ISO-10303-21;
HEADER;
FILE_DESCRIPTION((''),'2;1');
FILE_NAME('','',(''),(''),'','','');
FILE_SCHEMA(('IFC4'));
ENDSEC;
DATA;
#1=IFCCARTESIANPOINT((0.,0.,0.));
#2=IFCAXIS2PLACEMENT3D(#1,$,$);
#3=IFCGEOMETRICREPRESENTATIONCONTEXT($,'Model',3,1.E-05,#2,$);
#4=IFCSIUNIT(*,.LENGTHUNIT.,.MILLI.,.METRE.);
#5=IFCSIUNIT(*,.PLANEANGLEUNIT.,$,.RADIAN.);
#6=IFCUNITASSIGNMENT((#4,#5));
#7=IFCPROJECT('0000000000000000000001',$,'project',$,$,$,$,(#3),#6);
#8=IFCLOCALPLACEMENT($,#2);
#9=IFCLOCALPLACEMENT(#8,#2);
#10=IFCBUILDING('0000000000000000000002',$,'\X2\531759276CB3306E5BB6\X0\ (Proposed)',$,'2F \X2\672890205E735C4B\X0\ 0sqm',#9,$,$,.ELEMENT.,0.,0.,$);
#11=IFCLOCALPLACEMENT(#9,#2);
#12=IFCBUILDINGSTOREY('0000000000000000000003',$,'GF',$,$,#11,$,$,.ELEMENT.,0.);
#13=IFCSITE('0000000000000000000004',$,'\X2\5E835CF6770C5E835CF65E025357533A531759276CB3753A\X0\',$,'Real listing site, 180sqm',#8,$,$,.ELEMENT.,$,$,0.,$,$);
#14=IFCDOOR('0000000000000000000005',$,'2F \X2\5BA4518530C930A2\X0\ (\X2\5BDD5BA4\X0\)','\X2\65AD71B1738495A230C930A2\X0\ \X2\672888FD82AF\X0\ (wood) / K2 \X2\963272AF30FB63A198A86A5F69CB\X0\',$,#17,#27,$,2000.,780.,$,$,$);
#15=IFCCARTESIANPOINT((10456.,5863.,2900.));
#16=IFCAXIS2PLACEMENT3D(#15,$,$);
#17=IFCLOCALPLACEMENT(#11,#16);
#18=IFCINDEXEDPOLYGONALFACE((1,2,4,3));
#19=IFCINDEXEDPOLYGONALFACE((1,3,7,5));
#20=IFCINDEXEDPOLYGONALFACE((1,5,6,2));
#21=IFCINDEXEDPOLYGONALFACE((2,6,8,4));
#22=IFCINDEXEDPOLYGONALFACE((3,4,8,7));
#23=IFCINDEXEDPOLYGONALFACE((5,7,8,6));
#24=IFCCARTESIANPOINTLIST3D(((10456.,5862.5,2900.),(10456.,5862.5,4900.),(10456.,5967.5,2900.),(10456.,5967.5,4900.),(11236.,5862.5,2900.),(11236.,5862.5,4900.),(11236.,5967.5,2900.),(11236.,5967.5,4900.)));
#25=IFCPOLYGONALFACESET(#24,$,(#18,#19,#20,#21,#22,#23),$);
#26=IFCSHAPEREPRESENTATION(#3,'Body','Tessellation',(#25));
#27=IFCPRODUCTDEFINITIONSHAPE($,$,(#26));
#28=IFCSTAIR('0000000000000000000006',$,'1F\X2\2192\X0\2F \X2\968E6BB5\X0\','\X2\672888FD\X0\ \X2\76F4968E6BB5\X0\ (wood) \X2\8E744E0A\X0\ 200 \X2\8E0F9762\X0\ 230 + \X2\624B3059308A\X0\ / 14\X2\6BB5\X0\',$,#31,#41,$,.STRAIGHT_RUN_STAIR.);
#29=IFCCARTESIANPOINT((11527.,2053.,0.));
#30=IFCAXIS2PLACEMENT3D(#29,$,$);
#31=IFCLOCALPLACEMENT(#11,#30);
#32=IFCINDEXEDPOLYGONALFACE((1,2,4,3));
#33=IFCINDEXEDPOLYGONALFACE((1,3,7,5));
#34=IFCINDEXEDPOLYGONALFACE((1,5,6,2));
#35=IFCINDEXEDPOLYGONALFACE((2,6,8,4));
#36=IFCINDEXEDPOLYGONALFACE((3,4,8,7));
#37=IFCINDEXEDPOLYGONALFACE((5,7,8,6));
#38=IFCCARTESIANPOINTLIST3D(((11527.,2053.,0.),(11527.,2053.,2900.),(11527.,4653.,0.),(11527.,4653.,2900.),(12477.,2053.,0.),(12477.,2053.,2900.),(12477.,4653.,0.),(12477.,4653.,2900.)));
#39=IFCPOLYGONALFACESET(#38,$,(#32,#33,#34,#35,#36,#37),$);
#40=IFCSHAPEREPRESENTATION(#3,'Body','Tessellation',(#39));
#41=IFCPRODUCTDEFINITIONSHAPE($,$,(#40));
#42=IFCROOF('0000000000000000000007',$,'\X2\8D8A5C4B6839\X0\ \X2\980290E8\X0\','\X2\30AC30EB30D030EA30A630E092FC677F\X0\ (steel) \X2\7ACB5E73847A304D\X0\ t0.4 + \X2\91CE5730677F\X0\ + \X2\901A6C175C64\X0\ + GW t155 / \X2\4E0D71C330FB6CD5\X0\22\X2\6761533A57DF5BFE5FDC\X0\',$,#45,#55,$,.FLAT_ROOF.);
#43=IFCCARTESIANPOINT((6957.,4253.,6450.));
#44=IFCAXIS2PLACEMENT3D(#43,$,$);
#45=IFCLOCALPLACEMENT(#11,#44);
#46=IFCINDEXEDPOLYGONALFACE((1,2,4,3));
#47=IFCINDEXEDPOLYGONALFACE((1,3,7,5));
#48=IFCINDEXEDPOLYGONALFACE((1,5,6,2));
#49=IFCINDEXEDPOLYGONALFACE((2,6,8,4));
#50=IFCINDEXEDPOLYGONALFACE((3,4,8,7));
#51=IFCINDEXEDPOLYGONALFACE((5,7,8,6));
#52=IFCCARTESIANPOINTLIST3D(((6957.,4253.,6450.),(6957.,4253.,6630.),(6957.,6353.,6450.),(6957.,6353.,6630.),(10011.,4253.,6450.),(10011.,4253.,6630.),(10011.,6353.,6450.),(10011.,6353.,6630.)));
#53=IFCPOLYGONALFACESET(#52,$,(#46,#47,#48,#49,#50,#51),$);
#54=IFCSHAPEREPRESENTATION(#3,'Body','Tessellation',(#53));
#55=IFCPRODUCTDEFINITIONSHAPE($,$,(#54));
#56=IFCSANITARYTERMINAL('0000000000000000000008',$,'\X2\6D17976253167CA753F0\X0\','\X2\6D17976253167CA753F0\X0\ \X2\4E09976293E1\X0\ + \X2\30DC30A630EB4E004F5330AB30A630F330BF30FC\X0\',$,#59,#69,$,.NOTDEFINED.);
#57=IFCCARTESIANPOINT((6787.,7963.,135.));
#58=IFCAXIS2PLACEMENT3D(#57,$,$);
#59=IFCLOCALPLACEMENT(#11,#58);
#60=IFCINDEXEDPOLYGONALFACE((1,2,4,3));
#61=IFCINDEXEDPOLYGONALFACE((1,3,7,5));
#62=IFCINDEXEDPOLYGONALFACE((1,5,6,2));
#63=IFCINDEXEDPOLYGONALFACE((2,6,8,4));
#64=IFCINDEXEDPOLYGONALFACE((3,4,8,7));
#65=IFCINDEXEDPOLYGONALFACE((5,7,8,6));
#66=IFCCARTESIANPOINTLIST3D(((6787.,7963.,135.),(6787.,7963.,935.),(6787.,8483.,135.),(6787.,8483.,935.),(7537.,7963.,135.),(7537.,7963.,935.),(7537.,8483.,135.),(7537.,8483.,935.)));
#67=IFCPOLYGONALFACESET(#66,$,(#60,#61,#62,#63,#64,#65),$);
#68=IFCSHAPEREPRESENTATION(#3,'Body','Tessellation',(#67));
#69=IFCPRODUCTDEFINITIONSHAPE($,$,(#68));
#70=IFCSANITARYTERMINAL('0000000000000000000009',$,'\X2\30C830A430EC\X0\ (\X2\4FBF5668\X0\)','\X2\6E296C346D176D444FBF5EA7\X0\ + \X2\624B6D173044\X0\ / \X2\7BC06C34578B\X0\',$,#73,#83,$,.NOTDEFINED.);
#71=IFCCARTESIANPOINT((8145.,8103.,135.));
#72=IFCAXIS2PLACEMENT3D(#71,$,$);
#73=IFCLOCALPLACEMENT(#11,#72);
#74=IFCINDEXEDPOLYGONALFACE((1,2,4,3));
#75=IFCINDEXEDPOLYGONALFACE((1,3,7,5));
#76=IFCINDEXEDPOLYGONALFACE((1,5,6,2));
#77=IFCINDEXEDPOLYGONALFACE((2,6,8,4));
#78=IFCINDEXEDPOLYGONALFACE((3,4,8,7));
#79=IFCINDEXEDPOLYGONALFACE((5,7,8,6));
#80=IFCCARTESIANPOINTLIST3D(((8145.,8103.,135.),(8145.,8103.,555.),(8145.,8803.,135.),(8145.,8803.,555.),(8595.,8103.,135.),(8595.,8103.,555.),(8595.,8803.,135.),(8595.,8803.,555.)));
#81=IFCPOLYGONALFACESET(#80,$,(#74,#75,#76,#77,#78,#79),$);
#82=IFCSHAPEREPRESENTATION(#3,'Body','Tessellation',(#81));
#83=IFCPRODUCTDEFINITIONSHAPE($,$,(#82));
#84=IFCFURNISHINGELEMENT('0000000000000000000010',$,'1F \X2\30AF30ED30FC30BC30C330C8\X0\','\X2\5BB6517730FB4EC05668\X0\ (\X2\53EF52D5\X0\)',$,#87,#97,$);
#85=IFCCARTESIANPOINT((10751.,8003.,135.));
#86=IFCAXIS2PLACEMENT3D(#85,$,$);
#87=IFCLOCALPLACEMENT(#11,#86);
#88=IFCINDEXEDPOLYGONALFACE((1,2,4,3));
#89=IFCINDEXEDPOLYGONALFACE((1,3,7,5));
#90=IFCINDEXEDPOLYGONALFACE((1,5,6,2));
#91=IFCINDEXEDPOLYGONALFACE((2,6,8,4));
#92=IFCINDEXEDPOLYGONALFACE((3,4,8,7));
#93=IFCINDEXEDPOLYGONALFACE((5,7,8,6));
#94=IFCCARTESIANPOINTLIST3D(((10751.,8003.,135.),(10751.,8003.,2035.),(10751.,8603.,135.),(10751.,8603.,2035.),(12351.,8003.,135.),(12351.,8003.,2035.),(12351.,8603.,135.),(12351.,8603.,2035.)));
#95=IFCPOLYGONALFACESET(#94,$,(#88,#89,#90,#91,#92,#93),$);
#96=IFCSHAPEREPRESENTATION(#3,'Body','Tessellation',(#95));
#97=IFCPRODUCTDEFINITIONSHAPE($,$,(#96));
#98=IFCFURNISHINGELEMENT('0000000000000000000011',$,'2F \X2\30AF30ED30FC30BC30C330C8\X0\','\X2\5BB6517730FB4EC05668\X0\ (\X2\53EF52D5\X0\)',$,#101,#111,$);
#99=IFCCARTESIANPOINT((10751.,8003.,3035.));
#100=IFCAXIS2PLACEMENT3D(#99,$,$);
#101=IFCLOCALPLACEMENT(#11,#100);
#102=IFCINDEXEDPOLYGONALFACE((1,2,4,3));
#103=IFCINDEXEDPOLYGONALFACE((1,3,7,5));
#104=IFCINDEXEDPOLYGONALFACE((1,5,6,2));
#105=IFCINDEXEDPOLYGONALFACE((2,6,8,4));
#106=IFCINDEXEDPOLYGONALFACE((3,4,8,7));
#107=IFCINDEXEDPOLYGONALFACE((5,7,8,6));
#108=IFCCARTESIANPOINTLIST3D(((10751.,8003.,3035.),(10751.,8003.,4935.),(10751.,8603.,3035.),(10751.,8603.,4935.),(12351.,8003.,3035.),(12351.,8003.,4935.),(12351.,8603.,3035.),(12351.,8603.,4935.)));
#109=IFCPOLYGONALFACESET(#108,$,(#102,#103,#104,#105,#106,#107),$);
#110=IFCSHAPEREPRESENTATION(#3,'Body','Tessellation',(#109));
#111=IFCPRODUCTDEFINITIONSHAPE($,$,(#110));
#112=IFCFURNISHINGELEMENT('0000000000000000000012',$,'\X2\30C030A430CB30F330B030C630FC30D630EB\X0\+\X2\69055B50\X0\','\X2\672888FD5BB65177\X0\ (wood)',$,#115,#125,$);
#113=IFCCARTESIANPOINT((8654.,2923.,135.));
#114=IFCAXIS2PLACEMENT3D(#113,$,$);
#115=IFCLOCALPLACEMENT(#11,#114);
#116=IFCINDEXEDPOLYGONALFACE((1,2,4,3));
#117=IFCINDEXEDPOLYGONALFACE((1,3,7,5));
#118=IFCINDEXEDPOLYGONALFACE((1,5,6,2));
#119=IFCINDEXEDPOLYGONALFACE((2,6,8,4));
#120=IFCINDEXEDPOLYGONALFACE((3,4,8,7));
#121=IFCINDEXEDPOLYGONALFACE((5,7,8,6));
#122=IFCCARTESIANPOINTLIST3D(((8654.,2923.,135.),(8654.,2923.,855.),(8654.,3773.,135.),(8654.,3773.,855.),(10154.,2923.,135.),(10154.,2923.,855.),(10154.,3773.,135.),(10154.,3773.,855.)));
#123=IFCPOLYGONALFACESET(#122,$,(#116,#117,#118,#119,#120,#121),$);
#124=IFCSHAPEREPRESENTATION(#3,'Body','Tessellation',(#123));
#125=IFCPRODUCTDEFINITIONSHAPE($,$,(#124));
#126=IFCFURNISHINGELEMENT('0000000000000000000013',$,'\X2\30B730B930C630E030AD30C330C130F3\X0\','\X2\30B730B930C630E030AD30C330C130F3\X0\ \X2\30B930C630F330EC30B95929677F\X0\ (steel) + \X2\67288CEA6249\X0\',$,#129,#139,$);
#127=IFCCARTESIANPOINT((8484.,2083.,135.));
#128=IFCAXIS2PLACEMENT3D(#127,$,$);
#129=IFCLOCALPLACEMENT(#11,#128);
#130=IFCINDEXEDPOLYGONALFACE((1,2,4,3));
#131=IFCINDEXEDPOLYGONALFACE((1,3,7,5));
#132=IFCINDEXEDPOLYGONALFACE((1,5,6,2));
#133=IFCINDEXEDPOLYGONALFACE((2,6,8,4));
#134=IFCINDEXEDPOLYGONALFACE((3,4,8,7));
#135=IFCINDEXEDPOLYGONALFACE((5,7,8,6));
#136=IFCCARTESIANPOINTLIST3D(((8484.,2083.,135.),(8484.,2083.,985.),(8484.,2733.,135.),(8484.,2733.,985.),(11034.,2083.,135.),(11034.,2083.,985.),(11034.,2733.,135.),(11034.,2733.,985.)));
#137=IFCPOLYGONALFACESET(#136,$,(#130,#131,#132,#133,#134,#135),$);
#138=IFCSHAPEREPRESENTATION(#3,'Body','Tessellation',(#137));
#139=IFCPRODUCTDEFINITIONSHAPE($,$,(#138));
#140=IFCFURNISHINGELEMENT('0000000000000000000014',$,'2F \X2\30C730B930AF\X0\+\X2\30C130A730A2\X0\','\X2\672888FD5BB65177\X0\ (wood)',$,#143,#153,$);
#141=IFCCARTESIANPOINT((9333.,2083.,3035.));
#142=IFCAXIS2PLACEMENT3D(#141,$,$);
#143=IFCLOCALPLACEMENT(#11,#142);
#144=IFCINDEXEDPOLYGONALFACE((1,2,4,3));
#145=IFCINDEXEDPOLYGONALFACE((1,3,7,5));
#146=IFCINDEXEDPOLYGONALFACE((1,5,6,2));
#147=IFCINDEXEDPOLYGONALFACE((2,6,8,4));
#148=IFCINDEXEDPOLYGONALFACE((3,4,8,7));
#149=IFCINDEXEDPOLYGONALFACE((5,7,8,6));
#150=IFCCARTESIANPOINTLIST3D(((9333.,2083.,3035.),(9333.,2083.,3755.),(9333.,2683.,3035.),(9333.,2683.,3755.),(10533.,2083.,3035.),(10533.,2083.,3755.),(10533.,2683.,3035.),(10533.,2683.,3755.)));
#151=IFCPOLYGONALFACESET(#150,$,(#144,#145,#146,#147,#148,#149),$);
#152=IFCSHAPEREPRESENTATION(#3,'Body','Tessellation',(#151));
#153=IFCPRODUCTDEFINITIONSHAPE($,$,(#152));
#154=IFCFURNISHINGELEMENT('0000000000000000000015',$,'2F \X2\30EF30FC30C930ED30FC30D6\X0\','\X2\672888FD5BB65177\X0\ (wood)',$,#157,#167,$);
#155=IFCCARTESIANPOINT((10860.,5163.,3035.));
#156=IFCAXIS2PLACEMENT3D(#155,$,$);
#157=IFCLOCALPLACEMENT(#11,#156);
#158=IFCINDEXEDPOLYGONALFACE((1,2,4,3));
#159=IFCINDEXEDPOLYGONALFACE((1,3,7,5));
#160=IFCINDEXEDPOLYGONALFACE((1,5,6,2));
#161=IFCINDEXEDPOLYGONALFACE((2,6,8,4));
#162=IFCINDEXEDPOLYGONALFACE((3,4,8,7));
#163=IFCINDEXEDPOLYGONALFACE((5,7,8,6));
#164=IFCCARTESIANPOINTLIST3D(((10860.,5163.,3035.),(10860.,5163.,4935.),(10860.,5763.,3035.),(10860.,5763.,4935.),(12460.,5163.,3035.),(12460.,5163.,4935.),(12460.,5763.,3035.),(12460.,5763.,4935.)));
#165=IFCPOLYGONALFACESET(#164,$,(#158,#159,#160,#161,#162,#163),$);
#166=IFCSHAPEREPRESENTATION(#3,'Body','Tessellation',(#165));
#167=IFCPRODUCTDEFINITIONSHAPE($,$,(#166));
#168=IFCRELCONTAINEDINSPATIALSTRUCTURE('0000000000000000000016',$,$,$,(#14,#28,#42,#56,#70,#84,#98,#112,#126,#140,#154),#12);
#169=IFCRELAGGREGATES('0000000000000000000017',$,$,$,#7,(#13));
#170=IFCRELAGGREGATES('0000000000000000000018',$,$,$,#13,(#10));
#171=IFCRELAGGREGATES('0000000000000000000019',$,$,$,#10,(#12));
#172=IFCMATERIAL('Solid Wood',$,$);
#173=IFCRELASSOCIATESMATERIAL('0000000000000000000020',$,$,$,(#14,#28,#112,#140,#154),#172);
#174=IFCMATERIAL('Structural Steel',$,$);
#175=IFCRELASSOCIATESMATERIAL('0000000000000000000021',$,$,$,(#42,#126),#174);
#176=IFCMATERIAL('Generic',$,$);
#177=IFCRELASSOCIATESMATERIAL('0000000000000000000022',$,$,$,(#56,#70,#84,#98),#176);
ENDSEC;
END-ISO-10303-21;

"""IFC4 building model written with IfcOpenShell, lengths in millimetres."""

from ifc_helpers import new_model, si_unit, frame, frame_2d, origin, place, context, project, spatial, rectangle, extrude, material, element, save


model = new_model("IFC4")

# Units and contexts
model_context = context("Model", 3, precision=1e-05, world=origin())
ifc_project = project(units=[si_unit("LENGTHUNIT", "METRE", prefix="MILLI"), si_unit("PLANEANGLEUNIT", "RADIAN")], contexts=[model_context])

# Site, building, storey
site_placement = place(None, origin())
site = spatial("IfcSite", under=ifc_project, at=site_placement, Name="広島県広島市南区北大河町", ObjectType="Real listing site, 180sqm", CompositionType="ELEMENT", RefElevation=0.0)
building_placement = place(site_placement, origin())
building = spatial("IfcBuilding", under=site, at=building_placement, Name="北大河の家 (Proposed)", ObjectType="2F 木造平屋 0sqm", CompositionType="ELEMENT", ElevationOfRefHeight=0.0, ElevationOfTerrain=0.0)
storey_placement = place(building_placement, origin())
storey = spatial("IfcBuildingStorey", under=building, at=storey_placement, Name="GF", CompositionType="ELEMENT", Elevation=0.0)

# Shared definitions
ifc_material_1 = material(Name="Solid Wood")

# Door
door_1_placement = place(storey_placement, frame((10456.0, 5863.0, 2900.0)))
element("IfcDoor", 1, at=door_1_placement, inside=storey, material=ifc_material_1, Name="2F 室内ドア (寝室)", Description="断熱玄関ドア 木製芯 (wood) / K2 防犯・採風機構", OverallHeight=2000.0, OverallWidth=780.0, context=model_context, shape_type="SweptSolid", body=[
    extrude(rectangle(XDim=780.0, YDim=105.0, at=frame_2d((390.0, 52.0))), frame((10456.0, 5863.0, 2900.0)), (0.0, 0.0, 1.0), 2000.0),
])

# Stair
stair_placement = place(storey_placement, frame((11527.0, 2053.0, 0.0)))
element("IfcStair", 2, at=stair_placement, inside=storey, material=ifc_material_1, Name="1F→2F 階段", Description="木製 直階段 (wood) 蹴上 200 踏面 230 + 手すり / 14段", PredefinedType="STRAIGHT_RUN_STAIR", context=model_context, shape_type="SweptSolid", body=[
    extrude(rectangle(XDim=950.0, YDim=2600.0, at=frame_2d((475.0, 1300.0))), frame((11527.0, 2053.0, 0.0)), (0.0, 0.0, 1.0), 2900.0),
])

# Roof
ifc_material_2 = material(Name="Structural Steel")
roof_placement = place(storey_placement, frame((6957.0, 4253.0, 6450.0)))
element("IfcRoof", 3, at=roof_placement, inside=storey, material=ifc_material_2, Name="越屋根 頂部", Description="ガルバリウム鋼板 (steel) 立平葺き t0.4 + 野地板 + 通気層 + GW t155 / 不燃・法22条区域対応", PredefinedType="FLAT_ROOF", context=model_context, shape_type="SweptSolid", body=[
    extrude(rectangle(XDim=3054.0, YDim=2100.0, at=frame_2d((1527.0, 1050.0))), frame((6957.0, 4253.0, 6450.0)), (0.0, 0.0, 1.0), 180.0),
])

# Sanitary terminals
ifc_material_3 = material(Name="Generic")
sanitary_terminal_1_placement = place(storey_placement, frame((6787.0, 7963.0, 135.0)))
element("IfcSanitaryTerminal", 4, at=sanitary_terminal_1_placement, inside=storey, material=ifc_material_3, Name="洗面化粧台", Description="洗面化粧台 三面鏡 + ボウル一体カウンター", PredefinedType="NOTDEFINED", context=model_context, shape_type="SweptSolid", body=[
    extrude(rectangle(XDim=750.0, YDim=520.0, at=frame_2d((375.0, 260.0))), frame((6787.0, 7963.0, 135.0)), (0.0, 0.0, 1.0), 800.0),
])
sanitary_terminal_2_placement = place(storey_placement, frame((8145.0, 8103.0, 135.0)))
element("IfcSanitaryTerminal", 5, at=sanitary_terminal_2_placement, inside=storey, material=ifc_material_3, Name="トイレ (便器)", Description="温水洗浄便座 + 手洗い / 節水型", PredefinedType="NOTDEFINED", context=model_context, shape_type="SweptSolid", body=[
    extrude(rectangle(XDim=450.0, YDim=700.0, at=frame_2d((225.0, 350.0))), frame((8145.0, 8103.0, 135.0)), (0.0, 0.0, 1.0), 420.0),
])

# Furnishing elements
furnishing_1_placement = place(storey_placement, frame((10751.0, 8003.0, 135.0)))
element("IfcFurnishingElement", 6, at=furnishing_1_placement, inside=storey, material=ifc_material_3, Name="1F クローゼット", Description="家具・什器 (可動)", context=model_context, shape_type="SweptSolid", body=[
    extrude(rectangle(XDim=1600.0, YDim=600.0, at=frame_2d((800.0, 300.0))), frame((10751.0, 8003.0, 135.0)), (0.0, 0.0, 1.0), 1900.0),
])
furnishing_2_placement = place(storey_placement, frame((10751.0, 8003.0, 3035.0)))
element("IfcFurnishingElement", 7, at=furnishing_2_placement, inside=storey, material=ifc_material_3, Name="2F クローゼット", Description="家具・什器 (可動)", context=model_context, shape_type="SweptSolid", body=[
    extrude(rectangle(XDim=1600.0, YDim=600.0, at=frame_2d((800.0, 300.0))), frame((10751.0, 8003.0, 3035.0)), (0.0, 0.0, 1.0), 1900.0),
])
furnishing_3_placement = place(storey_placement, frame((8654.0, 2923.0, 135.0)))
element("IfcFurnishingElement", 8, at=furnishing_3_placement, inside=storey, material=ifc_material_1, Name="ダイニングテーブル+椅子", Description="木製家具 (wood)", context=model_context, shape_type="SweptSolid", body=[
    extrude(rectangle(XDim=1500.0, YDim=850.0, at=frame_2d((750.0, 425.0))), frame((8654.0, 2923.0, 135.0)), (0.0, 0.0, 1.0), 720.0),
])
furnishing_4_placement = place(storey_placement, frame((8484.0, 2083.0, 135.0)))
element("IfcFurnishingElement", 9, at=furnishing_4_placement, inside=storey, material=ifc_material_2, Name="システムキッチン", Description="システムキッチン ステンレス天板 (steel) + 木質扉", context=model_context, shape_type="SweptSolid", body=[
    extrude(rectangle(XDim=2550.0, YDim=650.0, at=frame_2d((1275.0, 325.0))), frame((8484.0, 2083.0, 135.0)), (0.0, 0.0, 1.0), 850.0),
])
furnishing_5_placement = place(storey_placement, frame((9333.0, 2083.0, 3035.0)))
element("IfcFurnishingElement", 10, at=furnishing_5_placement, inside=storey, material=ifc_material_1, Name="2F デスク+チェア", Description="木製家具 (wood)", context=model_context, shape_type="SweptSolid", body=[
    extrude(rectangle(XDim=1200.0, YDim=600.0, at=frame_2d((600.0, 300.0))), frame((9333.0, 2083.0, 3035.0)), (0.0, 0.0, 1.0), 720.0),
])
furnishing_6_placement = place(storey_placement, frame((10860.0, 5163.0, 3035.0)))
element("IfcFurnishingElement", 11, at=furnishing_6_placement, inside=storey, material=ifc_material_1, Name="2F ワードローブ", Description="木製家具 (wood)", context=model_context, shape_type="SweptSolid", body=[
    extrude(rectangle(XDim=1600.0, YDim=600.0, at=frame_2d((800.0, 300.0))), frame((10860.0, 5163.0, 3035.0)), (0.0, 0.0, 1.0), 1900.0),
])

save(model, "model.ifc")
